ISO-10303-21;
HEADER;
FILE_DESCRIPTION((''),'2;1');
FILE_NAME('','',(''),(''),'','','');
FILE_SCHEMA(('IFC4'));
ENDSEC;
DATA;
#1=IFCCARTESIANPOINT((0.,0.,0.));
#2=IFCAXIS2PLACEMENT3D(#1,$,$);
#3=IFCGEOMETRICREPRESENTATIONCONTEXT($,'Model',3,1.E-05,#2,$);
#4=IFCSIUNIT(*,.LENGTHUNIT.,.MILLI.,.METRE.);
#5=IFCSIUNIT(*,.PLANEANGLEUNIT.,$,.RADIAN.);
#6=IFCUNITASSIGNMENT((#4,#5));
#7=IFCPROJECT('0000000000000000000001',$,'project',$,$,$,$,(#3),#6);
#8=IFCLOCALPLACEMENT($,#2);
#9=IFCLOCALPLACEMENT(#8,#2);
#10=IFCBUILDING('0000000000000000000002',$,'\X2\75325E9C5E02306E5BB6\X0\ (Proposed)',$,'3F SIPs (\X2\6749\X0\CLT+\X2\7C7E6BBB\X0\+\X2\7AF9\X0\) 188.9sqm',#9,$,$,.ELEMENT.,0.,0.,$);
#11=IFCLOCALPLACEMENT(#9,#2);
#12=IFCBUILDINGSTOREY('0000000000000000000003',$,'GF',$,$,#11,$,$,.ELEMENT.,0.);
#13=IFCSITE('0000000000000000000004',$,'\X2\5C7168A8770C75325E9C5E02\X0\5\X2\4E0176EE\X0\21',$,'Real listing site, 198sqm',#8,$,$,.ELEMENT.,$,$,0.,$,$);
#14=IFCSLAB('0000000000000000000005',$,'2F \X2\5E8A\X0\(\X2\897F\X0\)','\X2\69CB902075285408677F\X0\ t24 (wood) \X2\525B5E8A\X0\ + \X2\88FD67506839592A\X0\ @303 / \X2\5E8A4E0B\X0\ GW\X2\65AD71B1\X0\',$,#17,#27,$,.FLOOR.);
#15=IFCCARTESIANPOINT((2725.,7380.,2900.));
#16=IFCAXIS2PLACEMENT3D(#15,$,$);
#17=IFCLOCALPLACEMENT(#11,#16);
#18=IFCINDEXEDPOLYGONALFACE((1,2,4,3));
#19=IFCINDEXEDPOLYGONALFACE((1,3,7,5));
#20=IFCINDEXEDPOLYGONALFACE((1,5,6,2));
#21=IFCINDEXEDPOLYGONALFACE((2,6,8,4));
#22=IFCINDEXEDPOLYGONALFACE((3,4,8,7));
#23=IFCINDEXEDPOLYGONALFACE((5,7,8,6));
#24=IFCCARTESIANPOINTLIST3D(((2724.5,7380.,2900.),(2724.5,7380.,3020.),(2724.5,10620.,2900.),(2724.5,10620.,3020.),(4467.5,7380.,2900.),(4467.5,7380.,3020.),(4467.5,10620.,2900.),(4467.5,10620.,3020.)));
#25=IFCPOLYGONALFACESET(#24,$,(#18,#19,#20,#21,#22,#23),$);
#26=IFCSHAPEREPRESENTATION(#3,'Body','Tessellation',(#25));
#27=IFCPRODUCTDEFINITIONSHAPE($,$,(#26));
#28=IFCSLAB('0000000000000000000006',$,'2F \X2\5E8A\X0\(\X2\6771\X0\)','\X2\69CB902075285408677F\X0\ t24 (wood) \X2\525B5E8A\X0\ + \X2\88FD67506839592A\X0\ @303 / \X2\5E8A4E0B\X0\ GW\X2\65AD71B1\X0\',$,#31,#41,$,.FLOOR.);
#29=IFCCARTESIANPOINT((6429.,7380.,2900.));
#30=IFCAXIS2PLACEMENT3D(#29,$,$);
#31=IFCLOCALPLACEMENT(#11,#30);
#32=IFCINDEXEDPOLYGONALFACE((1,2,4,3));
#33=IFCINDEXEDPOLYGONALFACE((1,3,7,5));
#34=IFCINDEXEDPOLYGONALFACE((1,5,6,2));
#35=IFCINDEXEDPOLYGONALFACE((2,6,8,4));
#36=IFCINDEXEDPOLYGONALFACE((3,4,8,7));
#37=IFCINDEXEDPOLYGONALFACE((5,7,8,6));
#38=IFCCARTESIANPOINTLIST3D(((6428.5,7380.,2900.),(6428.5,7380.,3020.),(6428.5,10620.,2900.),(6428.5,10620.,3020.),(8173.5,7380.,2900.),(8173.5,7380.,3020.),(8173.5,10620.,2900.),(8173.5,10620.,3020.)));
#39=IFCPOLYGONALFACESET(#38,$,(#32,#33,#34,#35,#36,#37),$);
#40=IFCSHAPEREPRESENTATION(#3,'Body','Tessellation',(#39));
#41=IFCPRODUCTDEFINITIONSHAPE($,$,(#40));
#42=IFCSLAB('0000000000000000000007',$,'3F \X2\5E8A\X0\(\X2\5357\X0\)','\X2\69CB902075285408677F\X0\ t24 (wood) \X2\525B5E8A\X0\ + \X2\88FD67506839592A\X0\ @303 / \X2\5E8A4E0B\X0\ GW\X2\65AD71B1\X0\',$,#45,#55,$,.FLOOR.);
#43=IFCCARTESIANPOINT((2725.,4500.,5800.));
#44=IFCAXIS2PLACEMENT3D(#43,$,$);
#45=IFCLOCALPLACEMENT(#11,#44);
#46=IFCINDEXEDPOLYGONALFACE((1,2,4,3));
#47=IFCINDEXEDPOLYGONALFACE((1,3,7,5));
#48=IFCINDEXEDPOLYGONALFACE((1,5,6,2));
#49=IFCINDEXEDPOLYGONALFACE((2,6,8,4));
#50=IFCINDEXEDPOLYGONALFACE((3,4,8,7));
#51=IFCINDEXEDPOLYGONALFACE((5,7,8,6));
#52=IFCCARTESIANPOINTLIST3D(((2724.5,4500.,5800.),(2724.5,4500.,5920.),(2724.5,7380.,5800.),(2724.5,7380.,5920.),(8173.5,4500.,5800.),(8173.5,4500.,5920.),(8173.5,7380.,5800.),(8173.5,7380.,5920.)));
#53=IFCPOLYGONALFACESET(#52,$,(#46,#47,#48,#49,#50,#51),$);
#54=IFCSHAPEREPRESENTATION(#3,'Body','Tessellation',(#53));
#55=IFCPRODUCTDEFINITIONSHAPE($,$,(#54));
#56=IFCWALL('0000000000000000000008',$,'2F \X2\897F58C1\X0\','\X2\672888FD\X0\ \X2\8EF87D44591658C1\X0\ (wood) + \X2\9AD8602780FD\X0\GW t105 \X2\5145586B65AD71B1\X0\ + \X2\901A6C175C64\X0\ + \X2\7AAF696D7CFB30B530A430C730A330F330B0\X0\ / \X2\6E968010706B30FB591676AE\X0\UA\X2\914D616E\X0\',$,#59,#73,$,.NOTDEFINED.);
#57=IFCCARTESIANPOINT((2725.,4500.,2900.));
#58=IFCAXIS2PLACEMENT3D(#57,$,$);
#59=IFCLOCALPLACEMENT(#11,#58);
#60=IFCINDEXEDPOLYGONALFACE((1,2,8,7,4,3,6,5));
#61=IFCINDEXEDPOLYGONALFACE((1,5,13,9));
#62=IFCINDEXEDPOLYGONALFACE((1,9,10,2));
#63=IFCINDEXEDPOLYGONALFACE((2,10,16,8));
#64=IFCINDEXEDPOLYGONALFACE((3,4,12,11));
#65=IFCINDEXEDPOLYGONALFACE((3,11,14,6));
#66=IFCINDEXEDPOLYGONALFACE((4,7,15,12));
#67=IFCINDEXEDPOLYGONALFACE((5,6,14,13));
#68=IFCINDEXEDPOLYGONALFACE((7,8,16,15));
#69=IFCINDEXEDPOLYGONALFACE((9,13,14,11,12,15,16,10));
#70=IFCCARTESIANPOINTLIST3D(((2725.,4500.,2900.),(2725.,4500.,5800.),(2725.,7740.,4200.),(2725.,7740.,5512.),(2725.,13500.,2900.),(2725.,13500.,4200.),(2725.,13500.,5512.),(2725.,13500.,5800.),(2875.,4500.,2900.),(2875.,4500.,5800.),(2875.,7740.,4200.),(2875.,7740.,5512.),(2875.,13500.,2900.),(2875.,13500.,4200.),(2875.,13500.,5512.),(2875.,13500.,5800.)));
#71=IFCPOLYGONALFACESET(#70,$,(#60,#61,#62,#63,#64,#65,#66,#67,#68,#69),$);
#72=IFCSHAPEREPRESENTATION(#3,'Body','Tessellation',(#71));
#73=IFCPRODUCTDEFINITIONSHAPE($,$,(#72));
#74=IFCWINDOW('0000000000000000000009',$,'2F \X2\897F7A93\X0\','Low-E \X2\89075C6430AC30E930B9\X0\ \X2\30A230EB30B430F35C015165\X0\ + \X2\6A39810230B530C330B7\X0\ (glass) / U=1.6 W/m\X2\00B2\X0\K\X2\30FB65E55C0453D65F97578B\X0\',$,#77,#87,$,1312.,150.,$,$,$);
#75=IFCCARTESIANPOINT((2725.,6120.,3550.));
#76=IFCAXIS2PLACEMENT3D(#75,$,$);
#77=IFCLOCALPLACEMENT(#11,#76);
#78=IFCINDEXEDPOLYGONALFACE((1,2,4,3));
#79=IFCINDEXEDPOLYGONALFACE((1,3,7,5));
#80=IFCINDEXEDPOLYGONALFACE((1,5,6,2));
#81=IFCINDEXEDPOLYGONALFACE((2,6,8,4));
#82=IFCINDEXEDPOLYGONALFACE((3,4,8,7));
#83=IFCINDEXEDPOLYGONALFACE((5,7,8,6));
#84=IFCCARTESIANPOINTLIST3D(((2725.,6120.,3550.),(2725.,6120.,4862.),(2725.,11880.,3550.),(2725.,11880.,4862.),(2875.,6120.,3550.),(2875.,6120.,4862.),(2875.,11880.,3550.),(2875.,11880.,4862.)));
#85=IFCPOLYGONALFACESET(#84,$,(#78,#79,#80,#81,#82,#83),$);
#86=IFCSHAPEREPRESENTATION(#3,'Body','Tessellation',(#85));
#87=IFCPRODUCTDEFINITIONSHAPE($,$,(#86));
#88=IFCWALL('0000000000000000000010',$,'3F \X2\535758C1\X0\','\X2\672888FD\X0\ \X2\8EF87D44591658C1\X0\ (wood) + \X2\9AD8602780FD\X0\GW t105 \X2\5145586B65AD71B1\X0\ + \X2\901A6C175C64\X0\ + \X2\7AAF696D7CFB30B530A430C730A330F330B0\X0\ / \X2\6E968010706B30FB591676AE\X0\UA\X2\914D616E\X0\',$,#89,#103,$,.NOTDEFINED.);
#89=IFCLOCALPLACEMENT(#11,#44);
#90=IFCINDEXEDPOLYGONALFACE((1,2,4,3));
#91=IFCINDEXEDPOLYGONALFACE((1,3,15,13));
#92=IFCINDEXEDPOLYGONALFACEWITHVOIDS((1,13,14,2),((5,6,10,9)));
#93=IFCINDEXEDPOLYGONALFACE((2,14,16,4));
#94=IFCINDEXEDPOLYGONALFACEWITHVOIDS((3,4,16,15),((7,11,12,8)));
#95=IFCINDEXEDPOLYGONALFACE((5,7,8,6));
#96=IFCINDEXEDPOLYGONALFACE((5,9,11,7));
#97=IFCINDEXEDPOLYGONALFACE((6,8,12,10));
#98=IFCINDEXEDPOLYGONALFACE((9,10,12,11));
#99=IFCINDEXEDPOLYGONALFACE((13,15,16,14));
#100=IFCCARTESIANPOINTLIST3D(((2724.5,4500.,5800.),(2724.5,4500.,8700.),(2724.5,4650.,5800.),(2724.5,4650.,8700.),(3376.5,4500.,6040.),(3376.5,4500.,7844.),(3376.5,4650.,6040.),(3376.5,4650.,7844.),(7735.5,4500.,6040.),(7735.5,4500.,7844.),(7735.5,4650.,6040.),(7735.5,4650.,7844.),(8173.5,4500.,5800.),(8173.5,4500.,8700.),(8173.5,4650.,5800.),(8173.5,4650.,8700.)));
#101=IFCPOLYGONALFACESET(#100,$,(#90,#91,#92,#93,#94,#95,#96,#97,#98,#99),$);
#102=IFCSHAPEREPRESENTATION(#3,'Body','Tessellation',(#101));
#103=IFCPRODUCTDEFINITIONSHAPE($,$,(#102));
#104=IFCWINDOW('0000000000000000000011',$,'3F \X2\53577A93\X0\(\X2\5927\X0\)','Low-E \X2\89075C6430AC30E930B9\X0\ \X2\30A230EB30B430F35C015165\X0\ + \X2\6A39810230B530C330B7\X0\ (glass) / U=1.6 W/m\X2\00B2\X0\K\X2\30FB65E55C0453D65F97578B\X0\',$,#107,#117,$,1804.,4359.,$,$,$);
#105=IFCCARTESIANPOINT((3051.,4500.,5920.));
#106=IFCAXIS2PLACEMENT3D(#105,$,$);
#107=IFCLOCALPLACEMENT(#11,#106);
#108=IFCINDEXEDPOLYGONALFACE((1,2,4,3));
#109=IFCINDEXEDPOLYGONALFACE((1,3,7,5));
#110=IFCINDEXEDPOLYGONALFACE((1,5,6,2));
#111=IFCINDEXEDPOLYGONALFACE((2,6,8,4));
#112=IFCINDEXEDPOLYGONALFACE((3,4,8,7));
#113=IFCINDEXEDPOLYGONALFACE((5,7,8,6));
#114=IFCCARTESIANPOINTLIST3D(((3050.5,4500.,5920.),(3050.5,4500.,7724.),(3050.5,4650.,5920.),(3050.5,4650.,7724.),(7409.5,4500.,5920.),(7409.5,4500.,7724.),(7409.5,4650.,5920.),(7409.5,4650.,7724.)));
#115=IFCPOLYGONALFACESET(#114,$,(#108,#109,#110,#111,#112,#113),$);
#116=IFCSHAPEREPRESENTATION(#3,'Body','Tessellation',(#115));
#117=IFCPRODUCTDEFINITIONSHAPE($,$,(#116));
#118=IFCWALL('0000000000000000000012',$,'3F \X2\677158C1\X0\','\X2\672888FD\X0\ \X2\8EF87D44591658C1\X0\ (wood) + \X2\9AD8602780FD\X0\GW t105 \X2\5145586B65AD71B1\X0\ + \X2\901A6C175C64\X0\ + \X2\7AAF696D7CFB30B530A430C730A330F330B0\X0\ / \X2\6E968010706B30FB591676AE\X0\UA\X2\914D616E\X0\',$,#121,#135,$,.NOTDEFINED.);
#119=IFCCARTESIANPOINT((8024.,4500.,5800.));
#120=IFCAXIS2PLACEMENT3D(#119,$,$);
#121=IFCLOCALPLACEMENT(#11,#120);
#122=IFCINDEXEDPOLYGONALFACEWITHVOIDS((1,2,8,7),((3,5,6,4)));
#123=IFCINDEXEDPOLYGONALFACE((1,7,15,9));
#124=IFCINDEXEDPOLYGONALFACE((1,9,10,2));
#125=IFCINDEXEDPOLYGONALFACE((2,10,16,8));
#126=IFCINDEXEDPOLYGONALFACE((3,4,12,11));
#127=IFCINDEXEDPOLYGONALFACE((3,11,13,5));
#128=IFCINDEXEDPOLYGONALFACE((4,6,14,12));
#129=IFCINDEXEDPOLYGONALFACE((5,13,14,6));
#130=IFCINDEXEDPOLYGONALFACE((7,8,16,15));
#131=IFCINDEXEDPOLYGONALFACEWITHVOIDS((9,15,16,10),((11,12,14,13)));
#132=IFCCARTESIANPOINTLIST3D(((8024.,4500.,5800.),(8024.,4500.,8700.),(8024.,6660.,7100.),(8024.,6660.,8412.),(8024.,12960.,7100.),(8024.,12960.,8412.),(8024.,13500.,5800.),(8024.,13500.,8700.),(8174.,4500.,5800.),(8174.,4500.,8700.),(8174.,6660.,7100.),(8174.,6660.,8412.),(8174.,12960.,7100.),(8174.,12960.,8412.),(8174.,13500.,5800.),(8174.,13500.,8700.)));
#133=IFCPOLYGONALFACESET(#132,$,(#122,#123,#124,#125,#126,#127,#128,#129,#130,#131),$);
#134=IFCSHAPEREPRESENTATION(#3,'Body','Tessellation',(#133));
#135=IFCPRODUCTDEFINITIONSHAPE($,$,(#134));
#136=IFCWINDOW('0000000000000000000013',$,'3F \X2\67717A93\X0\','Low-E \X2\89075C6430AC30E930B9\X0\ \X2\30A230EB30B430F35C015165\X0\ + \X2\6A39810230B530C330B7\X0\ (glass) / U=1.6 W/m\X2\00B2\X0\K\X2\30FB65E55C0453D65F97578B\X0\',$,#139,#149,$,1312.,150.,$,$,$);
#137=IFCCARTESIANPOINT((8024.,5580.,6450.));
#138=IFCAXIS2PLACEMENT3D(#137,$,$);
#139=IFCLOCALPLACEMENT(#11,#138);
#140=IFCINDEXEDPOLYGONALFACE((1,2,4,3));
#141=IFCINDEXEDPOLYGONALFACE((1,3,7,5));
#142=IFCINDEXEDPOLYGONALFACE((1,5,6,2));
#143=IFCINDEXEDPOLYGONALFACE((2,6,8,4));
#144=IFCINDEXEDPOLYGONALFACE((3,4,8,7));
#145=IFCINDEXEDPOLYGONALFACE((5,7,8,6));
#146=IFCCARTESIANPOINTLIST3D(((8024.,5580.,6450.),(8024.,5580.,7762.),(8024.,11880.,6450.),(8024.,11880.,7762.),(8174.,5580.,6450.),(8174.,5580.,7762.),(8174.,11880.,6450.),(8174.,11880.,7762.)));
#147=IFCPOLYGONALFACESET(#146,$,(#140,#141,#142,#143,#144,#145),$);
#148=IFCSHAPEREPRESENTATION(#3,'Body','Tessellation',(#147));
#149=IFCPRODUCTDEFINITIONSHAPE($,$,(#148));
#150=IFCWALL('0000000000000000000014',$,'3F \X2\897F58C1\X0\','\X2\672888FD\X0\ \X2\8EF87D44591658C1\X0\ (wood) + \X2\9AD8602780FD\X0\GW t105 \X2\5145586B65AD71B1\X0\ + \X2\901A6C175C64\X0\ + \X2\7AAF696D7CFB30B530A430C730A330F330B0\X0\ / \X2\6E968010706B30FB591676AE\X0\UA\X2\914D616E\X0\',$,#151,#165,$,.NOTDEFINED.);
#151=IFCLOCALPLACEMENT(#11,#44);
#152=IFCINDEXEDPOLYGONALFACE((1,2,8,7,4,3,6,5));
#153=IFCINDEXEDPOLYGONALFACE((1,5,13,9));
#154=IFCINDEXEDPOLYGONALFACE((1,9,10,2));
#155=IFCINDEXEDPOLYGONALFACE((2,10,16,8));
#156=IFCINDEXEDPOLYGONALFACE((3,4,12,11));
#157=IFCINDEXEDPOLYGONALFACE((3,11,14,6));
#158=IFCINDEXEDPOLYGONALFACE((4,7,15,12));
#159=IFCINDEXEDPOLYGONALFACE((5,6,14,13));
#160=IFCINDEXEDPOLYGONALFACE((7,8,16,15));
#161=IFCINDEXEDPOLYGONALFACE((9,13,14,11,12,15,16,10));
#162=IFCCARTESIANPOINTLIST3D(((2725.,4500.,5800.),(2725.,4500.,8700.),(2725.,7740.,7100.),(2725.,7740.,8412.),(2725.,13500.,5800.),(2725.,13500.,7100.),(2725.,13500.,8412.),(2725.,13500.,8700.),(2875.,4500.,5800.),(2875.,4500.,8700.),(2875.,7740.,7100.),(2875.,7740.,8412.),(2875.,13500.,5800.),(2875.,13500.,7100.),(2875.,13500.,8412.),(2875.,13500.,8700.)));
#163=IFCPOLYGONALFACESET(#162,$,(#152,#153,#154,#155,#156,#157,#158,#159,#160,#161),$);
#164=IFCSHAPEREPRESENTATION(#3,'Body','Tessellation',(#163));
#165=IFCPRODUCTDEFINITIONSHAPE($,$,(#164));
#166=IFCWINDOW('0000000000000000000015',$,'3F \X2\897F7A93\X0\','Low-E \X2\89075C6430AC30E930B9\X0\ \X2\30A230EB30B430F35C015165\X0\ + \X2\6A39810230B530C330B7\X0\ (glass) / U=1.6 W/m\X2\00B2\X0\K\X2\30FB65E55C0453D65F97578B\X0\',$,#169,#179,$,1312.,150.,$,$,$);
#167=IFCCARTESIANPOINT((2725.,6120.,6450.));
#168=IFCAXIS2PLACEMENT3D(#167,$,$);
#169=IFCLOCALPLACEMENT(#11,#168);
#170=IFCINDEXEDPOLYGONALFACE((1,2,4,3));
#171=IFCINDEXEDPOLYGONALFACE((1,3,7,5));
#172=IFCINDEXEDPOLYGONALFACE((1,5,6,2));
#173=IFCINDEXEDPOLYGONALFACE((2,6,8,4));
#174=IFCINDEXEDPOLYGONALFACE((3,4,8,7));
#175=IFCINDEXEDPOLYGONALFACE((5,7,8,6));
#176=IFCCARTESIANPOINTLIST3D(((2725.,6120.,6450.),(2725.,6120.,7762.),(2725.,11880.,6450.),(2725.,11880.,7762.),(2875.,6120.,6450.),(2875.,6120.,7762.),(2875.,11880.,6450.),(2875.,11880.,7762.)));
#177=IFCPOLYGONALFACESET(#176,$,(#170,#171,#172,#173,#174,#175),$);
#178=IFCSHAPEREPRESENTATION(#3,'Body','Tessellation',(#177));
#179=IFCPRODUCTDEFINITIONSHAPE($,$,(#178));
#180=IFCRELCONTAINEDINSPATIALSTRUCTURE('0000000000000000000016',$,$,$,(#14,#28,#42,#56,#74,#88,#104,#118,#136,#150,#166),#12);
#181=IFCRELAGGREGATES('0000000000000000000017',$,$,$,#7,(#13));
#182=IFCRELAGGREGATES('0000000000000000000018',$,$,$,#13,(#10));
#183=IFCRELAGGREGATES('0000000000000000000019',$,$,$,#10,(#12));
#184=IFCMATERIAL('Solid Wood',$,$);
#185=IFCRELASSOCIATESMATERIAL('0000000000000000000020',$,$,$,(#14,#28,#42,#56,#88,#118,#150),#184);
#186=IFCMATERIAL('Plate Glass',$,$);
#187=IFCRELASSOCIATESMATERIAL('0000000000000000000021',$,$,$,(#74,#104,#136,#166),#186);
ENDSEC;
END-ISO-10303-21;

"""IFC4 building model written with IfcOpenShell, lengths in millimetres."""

from ifc_helpers import new_model, si_unit, frame, frame_2d, origin, place, context, project, spatial, rectangle, extrude, material, element, fill, save


model = new_model("IFC4")

# Units and contexts
model_context = context("Model", 3, precision=1e-05, world=origin())
ifc_project = project(units=[si_unit("LENGTHUNIT", "METRE", prefix="MILLI"), si_unit("PLANEANGLEUNIT", "RADIAN")], contexts=[model_context])

# Site, building, storey
site_placement = place(None, origin())
site = spatial("IfcSite", under=ifc_project, at=site_placement, Name="山梨県甲府市5丁目21", ObjectType="Real listing site, 198sqm", CompositionType="ELEMENT", RefElevation=0.0)
building_placement = place(site_placement, origin())
building = spatial("IfcBuilding", under=site, at=building_placement, Name="甲府市の家 (Proposed)", ObjectType="3F SIPs (杉CLT+籾殻+竹) 188.9sqm", CompositionType="ELEMENT", ElevationOfRefHeight=0.0, ElevationOfTerrain=0.0)
storey_placement = place(building_placement, origin())
storey = spatial("IfcBuildingStorey", under=building, at=storey_placement, Name="GF", CompositionType="ELEMENT", Elevation=0.0)

# Slabs
ifc_material_1 = material(Name="Solid Wood")
slab_1_placement = place(storey_placement, frame((2725.0, 7380.0, 2900.0)))
element("IfcSlab", 1, at=slab_1_placement, inside=storey, material=ifc_material_1, Name="2F 床(西)", Description="構造用合板 t24 (wood) 剛床 + 製材根太 @303 / 床下 GW断熱", PredefinedType="FLOOR", context=model_context, shape_type="SweptSolid", body=[
    extrude(rectangle(XDim=1743.0, YDim=3240.0, at=frame_2d((871.0, 1620.0))), frame((2725.0, 7380.0, 2900.0)), (0.0, 0.0, 1.0), 120.0),
])
slab_2_placement = place(storey_placement, frame((6429.0, 7380.0, 2900.0)))
element("IfcSlab", 2, at=slab_2_placement, inside=storey, material=ifc_material_1, Name="2F 床(東)", Description="構造用合板 t24 (wood) 剛床 + 製材根太 @303 / 床下 GW断熱", PredefinedType="FLOOR", context=model_context, shape_type="SweptSolid", body=[
    extrude(rectangle(XDim=1745.0, YDim=3240.0, at=frame_2d((872.0, 1620.0))), frame((6429.0, 7380.0, 2900.0)), (0.0, 0.0, 1.0), 120.0),
])
slab_3_placement = place(storey_placement, frame((2725.0, 4500.0, 5800.0)))
element("IfcSlab", 3, at=slab_3_placement, inside=storey, material=ifc_material_1, Name="3F 床(南)", Description="構造用合板 t24 (wood) 剛床 + 製材根太 @303 / 床下 GW断熱", PredefinedType="FLOOR", context=model_context, shape_type="SweptSolid", body=[
    extrude(rectangle(XDim=5449.0, YDim=2880.0, at=frame_2d((2724.0, 1440.0))), frame((2725.0, 4500.0, 5800.0)), (0.0, 0.0, 1.0), 120.0),
])

# Walls, openings, windows
wall_1_placement = place(storey_placement, frame((2725.0, 4500.0, 2900.0)))
wall_1 = element("IfcWall", 4, at=wall_1_placement, inside=storey, material=ifc_material_1, Name="2F 西壁", Description="木製 軸組外壁 (wood) + 高性能GW t105 充填断熱 + 通気層 + 窯業系サイディング / 準耐火・外皮UA配慮", PredefinedType="NOTDEFINED", context=model_context, shape_type="SweptSolid", body=[
    extrude(rectangle(XDim=150.0, YDim=9000.0, at=frame_2d((75.0, 4500.0))), frame((2725.0, 4500.0, 2900.0)), (0.0, 0.0, 1.0), 2900.0),
])
opening_1_placement = place(storey_placement, frame((2725.0, 6120.0, 3550.0)))
opening_1 = element("IfcOpeningElement", 5, at=opening_1_placement, cuts=wall_1, PredefinedType="NOTDEFINED", context=model_context, shape_type="SweptSolid", body=[
    extrude(rectangle(XDim=150.0, YDim=5760.0, at=frame_2d((75.0, 2880.0))), frame((2725.0, 6120.0, 3550.0)), (0.0, 0.0, 1.0), 1312.0),
])
ifc_material_2 = material(Name="Plate Glass")
window_1_placement = place(storey_placement, frame((2725.0, 6120.0, 3550.0)))
window_1 = element("IfcWindow", 6, at=window_1_placement, inside=storey, material=ifc_material_2, Name="2F 西窓", Description="Low-E 複層ガラス アルゴン封入 + 樹脂サッシ (glass) / U=1.6 W/m²K・日射取得型", OverallHeight=1312.0, OverallWidth=150.0, context=model_context, shape_type="SweptSolid", body=[
    extrude(rectangle(XDim=150.0, YDim=5760.0, at=frame_2d((75.0, 2880.0))), frame((2725.0, 6120.0, 3550.0)), (0.0, 0.0, 1.0), 1312.0),
])
fill(opening_1, window_1)
wall_2_placement = place(storey_placement, frame((2725.0, 4500.0, 5800.0)))
wall_2 = element("IfcWall", 7, at=wall_2_placement, inside=storey, material=ifc_material_1, Name="3F 南壁", Description="木製 軸組外壁 (wood) + 高性能GW t105 充填断熱 + 通気層 + 窯業系サイディング / 準耐火・外皮UA配慮", PredefinedType="NOTDEFINED", context=model_context, shape_type="SweptSolid", body=[
    extrude(rectangle(XDim=5449.0, YDim=150.0, at=frame_2d((2724.0, 75.0))), frame((2725.0, 4500.0, 5800.0)), (0.0, 0.0, 1.0), 2900.0),
])
opening_2_placement = place(storey_placement, frame((3051.0, 4500.0, 5920.0)))
opening_2 = element("IfcOpeningElement", 8, at=opening_2_placement, cuts=wall_2, PredefinedType="NOTDEFINED", context=model_context, shape_type="SweptSolid", body=[
    extrude(rectangle(XDim=4359.0, YDim=150.0, at=frame_2d((2179.0, 75.0))), frame((3051.0, 4500.0, 5920.0)), (0.0, 0.0, 1.0), 1804.0),
])
window_2_placement = place(storey_placement, frame((3051.0, 4500.0, 5920.0)))
window_2 = element("IfcWindow", 9, at=window_2_placement, inside=storey, material=ifc_material_2, Name="3F 南窓(大)", Description="Low-E 複層ガラス アルゴン封入 + 樹脂サッシ (glass) / U=1.6 W/m²K・日射取得型", OverallHeight=1804.0, OverallWidth=4359.0, context=model_context, shape_type="SweptSolid", body=[
    extrude(rectangle(XDim=4359.0, YDim=150.0, at=frame_2d((2179.0, 75.0))), frame((3051.0, 4500.0, 5920.0)), (0.0, 0.0, 1.0), 1804.0),
])
fill(opening_2, window_2)
wall_3_placement = place(storey_placement, frame((8024.0, 4500.0, 5800.0)))
wall_3 = element("IfcWall", 10, at=wall_3_placement, inside=storey, material=ifc_material_1, Name="3F 東壁", Description="木製 軸組外壁 (wood) + 高性能GW t105 充填断熱 + 通気層 + 窯業系サイディング / 準耐火・外皮UA配慮", PredefinedType="NOTDEFINED", context=model_context, shape_type="SweptSolid", body=[
    extrude(rectangle(XDim=150.0, YDim=9000.0, at=frame_2d((75.0, 4500.0))), frame((8024.0, 4500.0, 5800.0)), (0.0, 0.0, 1.0), 2900.0),
])
opening_3_placement = place(storey_placement, frame((8024.0, 5580.0, 6450.0)))
opening_3 = element("IfcOpeningElement", 11, at=opening_3_placement, cuts=wall_3, PredefinedType="NOTDEFINED", context=model_context, shape_type="SweptSolid", body=[
    extrude(rectangle(XDim=150.0, YDim=6300.0, at=frame_2d((75.0, 3150.0))), frame((8024.0, 5580.0, 6450.0)), (0.0, 0.0, 1.0), 1312.0),
])
window_3_placement = place(storey_placement, frame((8024.0, 5580.0, 6450.0)))
window_3 = element("IfcWindow", 12, at=window_3_placement, inside=storey, material=ifc_material_2, Name="3F 東窓", Description="Low-E 複層ガラス アルゴン封入 + 樹脂サッシ (glass) / U=1.6 W/m²K・日射取得型", OverallHeight=1312.0, OverallWidth=150.0, context=model_context, shape_type="SweptSolid", body=[
    extrude(rectangle(XDim=150.0, YDim=6300.0, at=frame_2d((75.0, 3150.0))), frame((8024.0, 5580.0, 6450.0)), (0.0, 0.0, 1.0), 1312.0),
])
fill(opening_3, window_3)
wall_4_placement = place(storey_placement, frame((2725.0, 4500.0, 5800.0)))
wall_4 = element("IfcWall", 13, at=wall_4_placement, inside=storey, material=ifc_material_1, Name="3F 西壁", Description="木製 軸組外壁 (wood) + 高性能GW t105 充填断熱 + 通気層 + 窯業系サイディング / 準耐火・外皮UA配慮", PredefinedType="NOTDEFINED", context=model_context, shape_type="SweptSolid", body=[
    extrude(rectangle(XDim=150.0, YDim=9000.0, at=frame_2d((75.0, 4500.0))), frame((2725.0, 4500.0, 5800.0)), (0.0, 0.0, 1.0), 2900.0),
])
opening_4_placement = place(storey_placement, frame((2725.0, 6120.0, 6450.0)))
opening_4 = element("IfcOpeningElement", 14, at=opening_4_placement, cuts=wall_4, PredefinedType="NOTDEFINED", context=model_context, shape_type="SweptSolid", body=[
    extrude(rectangle(XDim=150.0, YDim=5760.0, at=frame_2d((75.0, 2880.0))), frame((2725.0, 6120.0, 6450.0)), (0.0, 0.0, 1.0), 1312.0),
])
window_4_placement = place(storey_placement, frame((2725.0, 6120.0, 6450.0)))
window_4 = element("IfcWindow", 15, at=window_4_placement, inside=storey, material=ifc_material_2, Name="3F 西窓", Description="Low-E 複層ガラス アルゴン封入 + 樹脂サッシ (glass) / U=1.6 W/m²K・日射取得型", OverallHeight=1312.0, OverallWidth=150.0, context=model_context, shape_type="SweptSolid", body=[
    extrude(rectangle(XDim=150.0, YDim=5760.0, at=frame_2d((75.0, 2880.0))), frame((2725.0, 6120.0, 6450.0)), (0.0, 0.0, 1.0), 1312.0),
])
fill(opening_4, window_4)

save(model, "model.ifc")
